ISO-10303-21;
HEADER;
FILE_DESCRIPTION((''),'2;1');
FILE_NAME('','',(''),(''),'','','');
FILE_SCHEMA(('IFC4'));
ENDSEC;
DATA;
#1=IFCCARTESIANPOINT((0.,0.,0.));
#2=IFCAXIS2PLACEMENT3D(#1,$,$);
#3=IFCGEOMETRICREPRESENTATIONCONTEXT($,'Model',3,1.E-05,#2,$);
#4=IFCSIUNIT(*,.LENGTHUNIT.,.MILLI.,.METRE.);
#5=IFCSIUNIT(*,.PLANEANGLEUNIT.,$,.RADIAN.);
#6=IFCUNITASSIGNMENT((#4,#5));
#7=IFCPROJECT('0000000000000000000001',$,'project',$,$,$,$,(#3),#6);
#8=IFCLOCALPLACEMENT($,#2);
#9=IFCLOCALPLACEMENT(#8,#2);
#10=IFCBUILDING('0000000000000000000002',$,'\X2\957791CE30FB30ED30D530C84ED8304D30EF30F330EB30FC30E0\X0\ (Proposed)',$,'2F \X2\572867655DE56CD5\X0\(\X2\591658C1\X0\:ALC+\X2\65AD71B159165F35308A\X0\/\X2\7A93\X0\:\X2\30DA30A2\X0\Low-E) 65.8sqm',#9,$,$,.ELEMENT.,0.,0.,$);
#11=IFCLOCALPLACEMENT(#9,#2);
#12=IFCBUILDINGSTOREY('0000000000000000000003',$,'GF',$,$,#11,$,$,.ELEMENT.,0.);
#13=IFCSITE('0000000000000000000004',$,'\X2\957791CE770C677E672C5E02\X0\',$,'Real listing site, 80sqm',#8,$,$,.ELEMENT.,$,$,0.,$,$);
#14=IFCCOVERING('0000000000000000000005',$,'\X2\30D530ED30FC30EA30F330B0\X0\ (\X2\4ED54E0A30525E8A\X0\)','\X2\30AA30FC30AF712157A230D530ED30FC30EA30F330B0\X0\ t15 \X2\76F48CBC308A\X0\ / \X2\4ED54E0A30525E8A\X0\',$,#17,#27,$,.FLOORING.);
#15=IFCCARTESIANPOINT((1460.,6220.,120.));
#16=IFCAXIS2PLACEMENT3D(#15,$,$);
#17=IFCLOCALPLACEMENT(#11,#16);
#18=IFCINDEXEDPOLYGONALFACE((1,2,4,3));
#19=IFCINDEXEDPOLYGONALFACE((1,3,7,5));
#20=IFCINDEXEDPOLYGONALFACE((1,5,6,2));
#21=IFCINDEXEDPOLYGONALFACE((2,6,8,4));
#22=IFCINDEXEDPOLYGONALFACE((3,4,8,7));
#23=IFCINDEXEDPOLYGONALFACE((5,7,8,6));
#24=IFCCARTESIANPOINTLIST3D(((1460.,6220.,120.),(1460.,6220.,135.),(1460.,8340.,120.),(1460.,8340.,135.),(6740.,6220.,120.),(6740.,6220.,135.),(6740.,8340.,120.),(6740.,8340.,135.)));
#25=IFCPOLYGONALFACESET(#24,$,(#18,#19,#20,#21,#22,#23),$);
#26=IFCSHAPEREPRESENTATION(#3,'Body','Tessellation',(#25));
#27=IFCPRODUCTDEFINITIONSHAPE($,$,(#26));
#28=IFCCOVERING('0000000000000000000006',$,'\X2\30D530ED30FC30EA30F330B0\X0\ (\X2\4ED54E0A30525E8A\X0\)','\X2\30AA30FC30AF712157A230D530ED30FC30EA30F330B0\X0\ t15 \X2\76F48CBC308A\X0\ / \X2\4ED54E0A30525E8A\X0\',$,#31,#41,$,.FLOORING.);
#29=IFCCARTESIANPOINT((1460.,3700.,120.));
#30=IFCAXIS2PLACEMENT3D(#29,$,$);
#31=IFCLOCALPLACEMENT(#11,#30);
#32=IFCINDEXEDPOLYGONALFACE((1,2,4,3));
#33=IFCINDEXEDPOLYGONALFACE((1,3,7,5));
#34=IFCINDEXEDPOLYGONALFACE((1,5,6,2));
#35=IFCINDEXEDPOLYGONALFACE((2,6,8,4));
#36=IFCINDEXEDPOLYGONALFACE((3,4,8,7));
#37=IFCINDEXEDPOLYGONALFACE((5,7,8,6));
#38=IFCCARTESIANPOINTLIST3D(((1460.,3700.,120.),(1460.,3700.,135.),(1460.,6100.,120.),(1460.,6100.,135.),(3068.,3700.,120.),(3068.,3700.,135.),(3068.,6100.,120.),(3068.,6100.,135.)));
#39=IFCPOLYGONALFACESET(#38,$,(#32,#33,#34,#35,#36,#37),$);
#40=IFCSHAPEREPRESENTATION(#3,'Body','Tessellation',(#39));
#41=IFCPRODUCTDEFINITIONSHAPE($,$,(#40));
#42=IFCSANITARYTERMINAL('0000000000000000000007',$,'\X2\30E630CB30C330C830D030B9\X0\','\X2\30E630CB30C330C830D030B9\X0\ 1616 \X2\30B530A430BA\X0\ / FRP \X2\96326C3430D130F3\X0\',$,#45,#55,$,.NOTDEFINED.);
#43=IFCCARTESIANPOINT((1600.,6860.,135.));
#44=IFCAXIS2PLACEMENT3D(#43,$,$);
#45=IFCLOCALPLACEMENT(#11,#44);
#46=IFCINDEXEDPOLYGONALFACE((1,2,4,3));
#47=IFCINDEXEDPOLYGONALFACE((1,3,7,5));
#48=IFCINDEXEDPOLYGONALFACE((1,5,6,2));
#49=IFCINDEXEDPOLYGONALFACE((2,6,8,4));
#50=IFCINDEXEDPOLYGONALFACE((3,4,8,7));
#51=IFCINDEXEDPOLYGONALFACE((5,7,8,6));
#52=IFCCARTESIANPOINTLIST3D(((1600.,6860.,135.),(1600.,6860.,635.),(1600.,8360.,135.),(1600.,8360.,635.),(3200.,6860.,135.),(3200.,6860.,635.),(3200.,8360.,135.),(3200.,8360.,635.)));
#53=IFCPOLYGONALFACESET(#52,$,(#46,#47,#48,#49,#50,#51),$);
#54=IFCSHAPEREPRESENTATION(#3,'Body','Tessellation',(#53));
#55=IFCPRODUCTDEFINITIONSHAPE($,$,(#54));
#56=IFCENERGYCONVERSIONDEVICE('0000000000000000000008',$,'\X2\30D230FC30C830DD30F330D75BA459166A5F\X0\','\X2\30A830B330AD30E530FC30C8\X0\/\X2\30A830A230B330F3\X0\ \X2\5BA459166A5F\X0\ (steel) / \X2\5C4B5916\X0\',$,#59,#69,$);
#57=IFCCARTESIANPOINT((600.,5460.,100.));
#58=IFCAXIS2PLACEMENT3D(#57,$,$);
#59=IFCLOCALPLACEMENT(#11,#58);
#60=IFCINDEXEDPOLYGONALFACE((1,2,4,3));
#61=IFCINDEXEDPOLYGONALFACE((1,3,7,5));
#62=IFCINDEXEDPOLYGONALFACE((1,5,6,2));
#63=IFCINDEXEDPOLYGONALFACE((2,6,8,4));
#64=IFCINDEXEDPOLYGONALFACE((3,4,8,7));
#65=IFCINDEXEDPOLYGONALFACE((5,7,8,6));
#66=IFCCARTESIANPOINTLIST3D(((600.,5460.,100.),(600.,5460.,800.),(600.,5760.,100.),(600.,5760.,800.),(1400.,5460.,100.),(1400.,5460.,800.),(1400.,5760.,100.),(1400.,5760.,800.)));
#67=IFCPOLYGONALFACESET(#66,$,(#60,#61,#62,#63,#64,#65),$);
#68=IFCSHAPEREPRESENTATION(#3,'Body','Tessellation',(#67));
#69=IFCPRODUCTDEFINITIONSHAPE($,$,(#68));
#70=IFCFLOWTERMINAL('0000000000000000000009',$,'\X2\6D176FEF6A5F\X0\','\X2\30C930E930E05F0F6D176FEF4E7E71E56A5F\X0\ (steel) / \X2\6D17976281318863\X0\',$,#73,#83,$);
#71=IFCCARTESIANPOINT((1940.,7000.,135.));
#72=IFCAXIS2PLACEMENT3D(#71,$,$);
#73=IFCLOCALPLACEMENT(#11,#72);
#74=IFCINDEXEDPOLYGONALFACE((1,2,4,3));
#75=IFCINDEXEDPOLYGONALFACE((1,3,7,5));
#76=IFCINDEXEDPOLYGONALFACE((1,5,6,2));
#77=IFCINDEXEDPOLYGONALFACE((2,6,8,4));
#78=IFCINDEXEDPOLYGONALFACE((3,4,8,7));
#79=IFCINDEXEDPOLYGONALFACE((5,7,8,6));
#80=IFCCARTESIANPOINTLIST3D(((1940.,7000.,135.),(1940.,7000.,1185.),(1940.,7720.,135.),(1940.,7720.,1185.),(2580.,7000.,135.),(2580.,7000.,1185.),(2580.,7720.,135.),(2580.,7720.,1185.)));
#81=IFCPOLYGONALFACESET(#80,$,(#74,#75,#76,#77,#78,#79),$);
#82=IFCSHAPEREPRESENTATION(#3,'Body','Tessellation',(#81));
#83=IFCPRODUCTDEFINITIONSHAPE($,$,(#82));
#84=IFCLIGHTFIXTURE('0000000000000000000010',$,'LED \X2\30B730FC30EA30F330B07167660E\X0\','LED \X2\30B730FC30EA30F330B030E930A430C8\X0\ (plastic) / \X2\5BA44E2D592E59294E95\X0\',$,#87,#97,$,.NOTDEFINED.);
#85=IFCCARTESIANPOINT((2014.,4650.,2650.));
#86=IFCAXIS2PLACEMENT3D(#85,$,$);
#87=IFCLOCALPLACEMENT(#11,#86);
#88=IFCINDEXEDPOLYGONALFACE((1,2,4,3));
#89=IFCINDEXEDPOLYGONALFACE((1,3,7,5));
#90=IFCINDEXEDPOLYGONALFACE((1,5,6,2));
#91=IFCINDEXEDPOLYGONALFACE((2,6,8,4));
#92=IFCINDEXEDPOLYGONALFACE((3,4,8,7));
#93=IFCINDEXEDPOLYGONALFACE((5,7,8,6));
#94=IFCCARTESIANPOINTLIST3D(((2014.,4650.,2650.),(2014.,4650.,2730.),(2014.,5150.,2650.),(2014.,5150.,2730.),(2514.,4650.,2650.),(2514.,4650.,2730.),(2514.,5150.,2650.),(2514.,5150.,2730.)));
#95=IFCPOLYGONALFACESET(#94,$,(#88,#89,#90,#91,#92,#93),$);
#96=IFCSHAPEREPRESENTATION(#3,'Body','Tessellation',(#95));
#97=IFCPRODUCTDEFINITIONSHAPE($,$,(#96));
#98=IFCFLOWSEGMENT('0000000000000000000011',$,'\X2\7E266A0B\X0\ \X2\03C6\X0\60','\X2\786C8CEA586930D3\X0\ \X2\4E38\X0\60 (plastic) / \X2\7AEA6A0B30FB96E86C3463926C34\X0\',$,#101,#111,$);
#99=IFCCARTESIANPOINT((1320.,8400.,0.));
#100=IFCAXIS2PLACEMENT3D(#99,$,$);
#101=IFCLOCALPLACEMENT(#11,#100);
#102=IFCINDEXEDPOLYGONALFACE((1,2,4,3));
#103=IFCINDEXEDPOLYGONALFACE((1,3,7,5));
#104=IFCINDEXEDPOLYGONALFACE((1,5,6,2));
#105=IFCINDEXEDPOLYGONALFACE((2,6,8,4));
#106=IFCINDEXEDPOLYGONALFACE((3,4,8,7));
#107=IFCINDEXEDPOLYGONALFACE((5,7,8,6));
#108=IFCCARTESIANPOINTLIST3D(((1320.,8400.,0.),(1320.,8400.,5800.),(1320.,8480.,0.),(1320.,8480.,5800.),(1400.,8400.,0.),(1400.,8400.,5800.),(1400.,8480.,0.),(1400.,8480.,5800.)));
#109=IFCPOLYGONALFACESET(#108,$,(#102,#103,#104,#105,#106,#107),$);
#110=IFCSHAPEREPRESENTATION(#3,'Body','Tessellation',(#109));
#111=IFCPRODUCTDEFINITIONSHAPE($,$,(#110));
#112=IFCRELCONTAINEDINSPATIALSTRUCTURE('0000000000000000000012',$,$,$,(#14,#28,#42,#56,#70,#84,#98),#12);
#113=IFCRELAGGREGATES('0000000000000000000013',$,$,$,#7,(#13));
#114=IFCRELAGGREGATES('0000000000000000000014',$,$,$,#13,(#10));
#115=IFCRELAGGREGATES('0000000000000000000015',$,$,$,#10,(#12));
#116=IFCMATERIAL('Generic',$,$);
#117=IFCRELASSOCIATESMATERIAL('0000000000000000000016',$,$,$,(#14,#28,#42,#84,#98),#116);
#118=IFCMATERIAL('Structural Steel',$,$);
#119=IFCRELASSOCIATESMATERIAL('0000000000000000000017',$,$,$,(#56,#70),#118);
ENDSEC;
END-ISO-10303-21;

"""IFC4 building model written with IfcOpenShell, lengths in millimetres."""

from ifc_helpers import new_model, si_unit, frame, frame_2d, origin, place, context, project, spatial, rectangle, extrude, material, element, save


model = new_model("IFC4")

# Units and contexts
model_context = context("Model", 3, precision=1e-05, world=origin())
ifc_project = project(units=[si_unit("LENGTHUNIT", "METRE", prefix="MILLI"), si_unit("PLANEANGLEUNIT", "RADIAN")], contexts=[model_context])

# Site, building, storey
site_placement = place(None, origin())
site = spatial("IfcSite", under=ifc_project, at=site_placement, Name="長野県松本市", ObjectType="Real listing site, 80sqm", CompositionType="ELEMENT", RefElevation=0.0)
building_placement = place(site_placement, origin())
building = spatial("IfcBuilding", under=site, at=building_placement, Name="長野・ロフト付きワンルーム (Proposed)", ObjectType="2F 在来工法(外壁:ALC+断熱外張り/窓:ペアLow-E) 65.8sqm", CompositionType="ELEMENT", ElevationOfRefHeight=0.0, ElevationOfTerrain=0.0)
storey_placement = place(building_placement, origin())
storey = spatial("IfcBuildingStorey", under=building, at=storey_placement, Name="GF", CompositionType="ELEMENT", Elevation=0.0)

# Coverings
ifc_material_1 = material(Name="Generic")
covering_1_placement = place(storey_placement, frame((1460.0, 6220.0, 120.0)))
element("IfcCovering", 1, at=covering_1_placement, inside=storey, material=ifc_material_1, Name="フローリング (仕上げ床)", Description="オーク無垢フローリング t15 直貼り / 仕上げ床", PredefinedType="FLOORING", context=model_context, shape_type="SweptSolid", body=[
    extrude(rectangle(XDim=5280.0, YDim=2120.0, at=frame_2d((2640.0, 1060.0))), frame((1460.0, 6220.0, 120.0)), (0.0, 0.0, 1.0), 15.0),
])
covering_2_placement = place(storey_placement, frame((1460.0, 3700.0, 120.0)))
element("IfcCovering", 2, at=covering_2_placement, inside=storey, material=ifc_material_1, Name="フローリング (仕上げ床)", Description="オーク無垢フローリング t15 直貼り / 仕上げ床", PredefinedType="FLOORING", context=model_context, shape_type="SweptSolid", body=[
    extrude(rectangle(XDim=1608.0, YDim=2400.0, at=frame_2d((804.0, 1200.0))), frame((1460.0, 3700.0, 120.0)), (0.0, 0.0, 1.0), 15.0),
])

# Sanitary terminal
sanitary_terminal_placement = place(storey_placement, frame((1600.0, 6860.0, 135.0)))
element("IfcSanitaryTerminal", 3, at=sanitary_terminal_placement, inside=storey, material=ifc_material_1, Name="ユニットバス", Description="ユニットバス 1616 サイズ / FRP 防水パン", PredefinedType="NOTDEFINED", context=model_context, shape_type="SweptSolid", body=[
    extrude(rectangle(XDim=1600.0, YDim=1500.0, at=frame_2d((800.0, 750.0))), frame((1600.0, 6860.0, 135.0)), (0.0, 0.0, 1.0), 500.0),
])

# Shared definitions
ifc_material_2 = material(Name="Structural Steel")

# Energy conversion device
energy_conversion_device_placement = place(storey_placement, frame((600.0, 5460.0, 100.0)))
element("IfcEnergyConversionDevice", 4, at=energy_conversion_device_placement, inside=storey, material=ifc_material_2, Name="ヒートポンプ室外機", Description="エコキュート/エアコン 室外機 (steel) / 屋外", context=model_context, shape_type="SweptSolid", body=[
    extrude(rectangle(XDim=800.0, YDim=300.0, at=frame_2d((400.0, 150.0))), frame((600.0, 5460.0, 100.0)), (0.0, 0.0, 1.0), 700.0),
])

# Flow terminal
flow_terminal_placement = place(storey_placement, frame((1940.0, 7000.0, 135.0)))
element("IfcFlowTerminal", 5, at=flow_terminal_placement, inside=storey, material=ifc_material_2, Name="洗濯機", Description="ドラム式洗濯乾燥機 (steel) / 洗面脱衣", context=model_context, shape_type="SweptSolid", body=[
    extrude(rectangle(XDim=640.0, YDim=720.0, at=frame_2d((320.0, 360.0))), frame((1940.0, 7000.0, 135.0)), (0.0, 0.0, 1.0), 1050.0),
])

# Light fixture
light_fixture_placement = place(storey_placement, frame((2014.0, 4650.0, 2650.0)))
element("IfcLightFixture", 6, at=light_fixture_placement, inside=storey, material=ifc_material_1, Name="LED シーリング照明", Description="LED シーリングライト (plastic) / 室中央天井", PredefinedType="NOTDEFINED", context=model_context, shape_type="SweptSolid", body=[
    extrude(rectangle(XDim=500.0, YDim=500.0, at=frame_2d((250.0, 250.0))), frame((2014.0, 4650.0, 2650.0)), (0.0, 0.0, 1.0), 80.0),
])

# Flow segment
flow_segment_placement = place(storey_placement, frame((1320.0, 8400.0, 0.0)))
element("IfcFlowSegment", 7, at=flow_segment_placement, inside=storey, material=ifc_material_1, Name="縦樋 φ60", Description="硬質塩ビ 丸60 (plastic) / 竪樋・雨水排水", context=model_context, shape_type="SweptSolid", body=[
    extrude(rectangle(XDim=80.0, YDim=80.0, at=frame_2d((40.0, 40.0))), frame((1320.0, 8400.0, 0.0)), (0.0, 0.0, 1.0), 5800.0),
])

save(model, "model.ifc")
